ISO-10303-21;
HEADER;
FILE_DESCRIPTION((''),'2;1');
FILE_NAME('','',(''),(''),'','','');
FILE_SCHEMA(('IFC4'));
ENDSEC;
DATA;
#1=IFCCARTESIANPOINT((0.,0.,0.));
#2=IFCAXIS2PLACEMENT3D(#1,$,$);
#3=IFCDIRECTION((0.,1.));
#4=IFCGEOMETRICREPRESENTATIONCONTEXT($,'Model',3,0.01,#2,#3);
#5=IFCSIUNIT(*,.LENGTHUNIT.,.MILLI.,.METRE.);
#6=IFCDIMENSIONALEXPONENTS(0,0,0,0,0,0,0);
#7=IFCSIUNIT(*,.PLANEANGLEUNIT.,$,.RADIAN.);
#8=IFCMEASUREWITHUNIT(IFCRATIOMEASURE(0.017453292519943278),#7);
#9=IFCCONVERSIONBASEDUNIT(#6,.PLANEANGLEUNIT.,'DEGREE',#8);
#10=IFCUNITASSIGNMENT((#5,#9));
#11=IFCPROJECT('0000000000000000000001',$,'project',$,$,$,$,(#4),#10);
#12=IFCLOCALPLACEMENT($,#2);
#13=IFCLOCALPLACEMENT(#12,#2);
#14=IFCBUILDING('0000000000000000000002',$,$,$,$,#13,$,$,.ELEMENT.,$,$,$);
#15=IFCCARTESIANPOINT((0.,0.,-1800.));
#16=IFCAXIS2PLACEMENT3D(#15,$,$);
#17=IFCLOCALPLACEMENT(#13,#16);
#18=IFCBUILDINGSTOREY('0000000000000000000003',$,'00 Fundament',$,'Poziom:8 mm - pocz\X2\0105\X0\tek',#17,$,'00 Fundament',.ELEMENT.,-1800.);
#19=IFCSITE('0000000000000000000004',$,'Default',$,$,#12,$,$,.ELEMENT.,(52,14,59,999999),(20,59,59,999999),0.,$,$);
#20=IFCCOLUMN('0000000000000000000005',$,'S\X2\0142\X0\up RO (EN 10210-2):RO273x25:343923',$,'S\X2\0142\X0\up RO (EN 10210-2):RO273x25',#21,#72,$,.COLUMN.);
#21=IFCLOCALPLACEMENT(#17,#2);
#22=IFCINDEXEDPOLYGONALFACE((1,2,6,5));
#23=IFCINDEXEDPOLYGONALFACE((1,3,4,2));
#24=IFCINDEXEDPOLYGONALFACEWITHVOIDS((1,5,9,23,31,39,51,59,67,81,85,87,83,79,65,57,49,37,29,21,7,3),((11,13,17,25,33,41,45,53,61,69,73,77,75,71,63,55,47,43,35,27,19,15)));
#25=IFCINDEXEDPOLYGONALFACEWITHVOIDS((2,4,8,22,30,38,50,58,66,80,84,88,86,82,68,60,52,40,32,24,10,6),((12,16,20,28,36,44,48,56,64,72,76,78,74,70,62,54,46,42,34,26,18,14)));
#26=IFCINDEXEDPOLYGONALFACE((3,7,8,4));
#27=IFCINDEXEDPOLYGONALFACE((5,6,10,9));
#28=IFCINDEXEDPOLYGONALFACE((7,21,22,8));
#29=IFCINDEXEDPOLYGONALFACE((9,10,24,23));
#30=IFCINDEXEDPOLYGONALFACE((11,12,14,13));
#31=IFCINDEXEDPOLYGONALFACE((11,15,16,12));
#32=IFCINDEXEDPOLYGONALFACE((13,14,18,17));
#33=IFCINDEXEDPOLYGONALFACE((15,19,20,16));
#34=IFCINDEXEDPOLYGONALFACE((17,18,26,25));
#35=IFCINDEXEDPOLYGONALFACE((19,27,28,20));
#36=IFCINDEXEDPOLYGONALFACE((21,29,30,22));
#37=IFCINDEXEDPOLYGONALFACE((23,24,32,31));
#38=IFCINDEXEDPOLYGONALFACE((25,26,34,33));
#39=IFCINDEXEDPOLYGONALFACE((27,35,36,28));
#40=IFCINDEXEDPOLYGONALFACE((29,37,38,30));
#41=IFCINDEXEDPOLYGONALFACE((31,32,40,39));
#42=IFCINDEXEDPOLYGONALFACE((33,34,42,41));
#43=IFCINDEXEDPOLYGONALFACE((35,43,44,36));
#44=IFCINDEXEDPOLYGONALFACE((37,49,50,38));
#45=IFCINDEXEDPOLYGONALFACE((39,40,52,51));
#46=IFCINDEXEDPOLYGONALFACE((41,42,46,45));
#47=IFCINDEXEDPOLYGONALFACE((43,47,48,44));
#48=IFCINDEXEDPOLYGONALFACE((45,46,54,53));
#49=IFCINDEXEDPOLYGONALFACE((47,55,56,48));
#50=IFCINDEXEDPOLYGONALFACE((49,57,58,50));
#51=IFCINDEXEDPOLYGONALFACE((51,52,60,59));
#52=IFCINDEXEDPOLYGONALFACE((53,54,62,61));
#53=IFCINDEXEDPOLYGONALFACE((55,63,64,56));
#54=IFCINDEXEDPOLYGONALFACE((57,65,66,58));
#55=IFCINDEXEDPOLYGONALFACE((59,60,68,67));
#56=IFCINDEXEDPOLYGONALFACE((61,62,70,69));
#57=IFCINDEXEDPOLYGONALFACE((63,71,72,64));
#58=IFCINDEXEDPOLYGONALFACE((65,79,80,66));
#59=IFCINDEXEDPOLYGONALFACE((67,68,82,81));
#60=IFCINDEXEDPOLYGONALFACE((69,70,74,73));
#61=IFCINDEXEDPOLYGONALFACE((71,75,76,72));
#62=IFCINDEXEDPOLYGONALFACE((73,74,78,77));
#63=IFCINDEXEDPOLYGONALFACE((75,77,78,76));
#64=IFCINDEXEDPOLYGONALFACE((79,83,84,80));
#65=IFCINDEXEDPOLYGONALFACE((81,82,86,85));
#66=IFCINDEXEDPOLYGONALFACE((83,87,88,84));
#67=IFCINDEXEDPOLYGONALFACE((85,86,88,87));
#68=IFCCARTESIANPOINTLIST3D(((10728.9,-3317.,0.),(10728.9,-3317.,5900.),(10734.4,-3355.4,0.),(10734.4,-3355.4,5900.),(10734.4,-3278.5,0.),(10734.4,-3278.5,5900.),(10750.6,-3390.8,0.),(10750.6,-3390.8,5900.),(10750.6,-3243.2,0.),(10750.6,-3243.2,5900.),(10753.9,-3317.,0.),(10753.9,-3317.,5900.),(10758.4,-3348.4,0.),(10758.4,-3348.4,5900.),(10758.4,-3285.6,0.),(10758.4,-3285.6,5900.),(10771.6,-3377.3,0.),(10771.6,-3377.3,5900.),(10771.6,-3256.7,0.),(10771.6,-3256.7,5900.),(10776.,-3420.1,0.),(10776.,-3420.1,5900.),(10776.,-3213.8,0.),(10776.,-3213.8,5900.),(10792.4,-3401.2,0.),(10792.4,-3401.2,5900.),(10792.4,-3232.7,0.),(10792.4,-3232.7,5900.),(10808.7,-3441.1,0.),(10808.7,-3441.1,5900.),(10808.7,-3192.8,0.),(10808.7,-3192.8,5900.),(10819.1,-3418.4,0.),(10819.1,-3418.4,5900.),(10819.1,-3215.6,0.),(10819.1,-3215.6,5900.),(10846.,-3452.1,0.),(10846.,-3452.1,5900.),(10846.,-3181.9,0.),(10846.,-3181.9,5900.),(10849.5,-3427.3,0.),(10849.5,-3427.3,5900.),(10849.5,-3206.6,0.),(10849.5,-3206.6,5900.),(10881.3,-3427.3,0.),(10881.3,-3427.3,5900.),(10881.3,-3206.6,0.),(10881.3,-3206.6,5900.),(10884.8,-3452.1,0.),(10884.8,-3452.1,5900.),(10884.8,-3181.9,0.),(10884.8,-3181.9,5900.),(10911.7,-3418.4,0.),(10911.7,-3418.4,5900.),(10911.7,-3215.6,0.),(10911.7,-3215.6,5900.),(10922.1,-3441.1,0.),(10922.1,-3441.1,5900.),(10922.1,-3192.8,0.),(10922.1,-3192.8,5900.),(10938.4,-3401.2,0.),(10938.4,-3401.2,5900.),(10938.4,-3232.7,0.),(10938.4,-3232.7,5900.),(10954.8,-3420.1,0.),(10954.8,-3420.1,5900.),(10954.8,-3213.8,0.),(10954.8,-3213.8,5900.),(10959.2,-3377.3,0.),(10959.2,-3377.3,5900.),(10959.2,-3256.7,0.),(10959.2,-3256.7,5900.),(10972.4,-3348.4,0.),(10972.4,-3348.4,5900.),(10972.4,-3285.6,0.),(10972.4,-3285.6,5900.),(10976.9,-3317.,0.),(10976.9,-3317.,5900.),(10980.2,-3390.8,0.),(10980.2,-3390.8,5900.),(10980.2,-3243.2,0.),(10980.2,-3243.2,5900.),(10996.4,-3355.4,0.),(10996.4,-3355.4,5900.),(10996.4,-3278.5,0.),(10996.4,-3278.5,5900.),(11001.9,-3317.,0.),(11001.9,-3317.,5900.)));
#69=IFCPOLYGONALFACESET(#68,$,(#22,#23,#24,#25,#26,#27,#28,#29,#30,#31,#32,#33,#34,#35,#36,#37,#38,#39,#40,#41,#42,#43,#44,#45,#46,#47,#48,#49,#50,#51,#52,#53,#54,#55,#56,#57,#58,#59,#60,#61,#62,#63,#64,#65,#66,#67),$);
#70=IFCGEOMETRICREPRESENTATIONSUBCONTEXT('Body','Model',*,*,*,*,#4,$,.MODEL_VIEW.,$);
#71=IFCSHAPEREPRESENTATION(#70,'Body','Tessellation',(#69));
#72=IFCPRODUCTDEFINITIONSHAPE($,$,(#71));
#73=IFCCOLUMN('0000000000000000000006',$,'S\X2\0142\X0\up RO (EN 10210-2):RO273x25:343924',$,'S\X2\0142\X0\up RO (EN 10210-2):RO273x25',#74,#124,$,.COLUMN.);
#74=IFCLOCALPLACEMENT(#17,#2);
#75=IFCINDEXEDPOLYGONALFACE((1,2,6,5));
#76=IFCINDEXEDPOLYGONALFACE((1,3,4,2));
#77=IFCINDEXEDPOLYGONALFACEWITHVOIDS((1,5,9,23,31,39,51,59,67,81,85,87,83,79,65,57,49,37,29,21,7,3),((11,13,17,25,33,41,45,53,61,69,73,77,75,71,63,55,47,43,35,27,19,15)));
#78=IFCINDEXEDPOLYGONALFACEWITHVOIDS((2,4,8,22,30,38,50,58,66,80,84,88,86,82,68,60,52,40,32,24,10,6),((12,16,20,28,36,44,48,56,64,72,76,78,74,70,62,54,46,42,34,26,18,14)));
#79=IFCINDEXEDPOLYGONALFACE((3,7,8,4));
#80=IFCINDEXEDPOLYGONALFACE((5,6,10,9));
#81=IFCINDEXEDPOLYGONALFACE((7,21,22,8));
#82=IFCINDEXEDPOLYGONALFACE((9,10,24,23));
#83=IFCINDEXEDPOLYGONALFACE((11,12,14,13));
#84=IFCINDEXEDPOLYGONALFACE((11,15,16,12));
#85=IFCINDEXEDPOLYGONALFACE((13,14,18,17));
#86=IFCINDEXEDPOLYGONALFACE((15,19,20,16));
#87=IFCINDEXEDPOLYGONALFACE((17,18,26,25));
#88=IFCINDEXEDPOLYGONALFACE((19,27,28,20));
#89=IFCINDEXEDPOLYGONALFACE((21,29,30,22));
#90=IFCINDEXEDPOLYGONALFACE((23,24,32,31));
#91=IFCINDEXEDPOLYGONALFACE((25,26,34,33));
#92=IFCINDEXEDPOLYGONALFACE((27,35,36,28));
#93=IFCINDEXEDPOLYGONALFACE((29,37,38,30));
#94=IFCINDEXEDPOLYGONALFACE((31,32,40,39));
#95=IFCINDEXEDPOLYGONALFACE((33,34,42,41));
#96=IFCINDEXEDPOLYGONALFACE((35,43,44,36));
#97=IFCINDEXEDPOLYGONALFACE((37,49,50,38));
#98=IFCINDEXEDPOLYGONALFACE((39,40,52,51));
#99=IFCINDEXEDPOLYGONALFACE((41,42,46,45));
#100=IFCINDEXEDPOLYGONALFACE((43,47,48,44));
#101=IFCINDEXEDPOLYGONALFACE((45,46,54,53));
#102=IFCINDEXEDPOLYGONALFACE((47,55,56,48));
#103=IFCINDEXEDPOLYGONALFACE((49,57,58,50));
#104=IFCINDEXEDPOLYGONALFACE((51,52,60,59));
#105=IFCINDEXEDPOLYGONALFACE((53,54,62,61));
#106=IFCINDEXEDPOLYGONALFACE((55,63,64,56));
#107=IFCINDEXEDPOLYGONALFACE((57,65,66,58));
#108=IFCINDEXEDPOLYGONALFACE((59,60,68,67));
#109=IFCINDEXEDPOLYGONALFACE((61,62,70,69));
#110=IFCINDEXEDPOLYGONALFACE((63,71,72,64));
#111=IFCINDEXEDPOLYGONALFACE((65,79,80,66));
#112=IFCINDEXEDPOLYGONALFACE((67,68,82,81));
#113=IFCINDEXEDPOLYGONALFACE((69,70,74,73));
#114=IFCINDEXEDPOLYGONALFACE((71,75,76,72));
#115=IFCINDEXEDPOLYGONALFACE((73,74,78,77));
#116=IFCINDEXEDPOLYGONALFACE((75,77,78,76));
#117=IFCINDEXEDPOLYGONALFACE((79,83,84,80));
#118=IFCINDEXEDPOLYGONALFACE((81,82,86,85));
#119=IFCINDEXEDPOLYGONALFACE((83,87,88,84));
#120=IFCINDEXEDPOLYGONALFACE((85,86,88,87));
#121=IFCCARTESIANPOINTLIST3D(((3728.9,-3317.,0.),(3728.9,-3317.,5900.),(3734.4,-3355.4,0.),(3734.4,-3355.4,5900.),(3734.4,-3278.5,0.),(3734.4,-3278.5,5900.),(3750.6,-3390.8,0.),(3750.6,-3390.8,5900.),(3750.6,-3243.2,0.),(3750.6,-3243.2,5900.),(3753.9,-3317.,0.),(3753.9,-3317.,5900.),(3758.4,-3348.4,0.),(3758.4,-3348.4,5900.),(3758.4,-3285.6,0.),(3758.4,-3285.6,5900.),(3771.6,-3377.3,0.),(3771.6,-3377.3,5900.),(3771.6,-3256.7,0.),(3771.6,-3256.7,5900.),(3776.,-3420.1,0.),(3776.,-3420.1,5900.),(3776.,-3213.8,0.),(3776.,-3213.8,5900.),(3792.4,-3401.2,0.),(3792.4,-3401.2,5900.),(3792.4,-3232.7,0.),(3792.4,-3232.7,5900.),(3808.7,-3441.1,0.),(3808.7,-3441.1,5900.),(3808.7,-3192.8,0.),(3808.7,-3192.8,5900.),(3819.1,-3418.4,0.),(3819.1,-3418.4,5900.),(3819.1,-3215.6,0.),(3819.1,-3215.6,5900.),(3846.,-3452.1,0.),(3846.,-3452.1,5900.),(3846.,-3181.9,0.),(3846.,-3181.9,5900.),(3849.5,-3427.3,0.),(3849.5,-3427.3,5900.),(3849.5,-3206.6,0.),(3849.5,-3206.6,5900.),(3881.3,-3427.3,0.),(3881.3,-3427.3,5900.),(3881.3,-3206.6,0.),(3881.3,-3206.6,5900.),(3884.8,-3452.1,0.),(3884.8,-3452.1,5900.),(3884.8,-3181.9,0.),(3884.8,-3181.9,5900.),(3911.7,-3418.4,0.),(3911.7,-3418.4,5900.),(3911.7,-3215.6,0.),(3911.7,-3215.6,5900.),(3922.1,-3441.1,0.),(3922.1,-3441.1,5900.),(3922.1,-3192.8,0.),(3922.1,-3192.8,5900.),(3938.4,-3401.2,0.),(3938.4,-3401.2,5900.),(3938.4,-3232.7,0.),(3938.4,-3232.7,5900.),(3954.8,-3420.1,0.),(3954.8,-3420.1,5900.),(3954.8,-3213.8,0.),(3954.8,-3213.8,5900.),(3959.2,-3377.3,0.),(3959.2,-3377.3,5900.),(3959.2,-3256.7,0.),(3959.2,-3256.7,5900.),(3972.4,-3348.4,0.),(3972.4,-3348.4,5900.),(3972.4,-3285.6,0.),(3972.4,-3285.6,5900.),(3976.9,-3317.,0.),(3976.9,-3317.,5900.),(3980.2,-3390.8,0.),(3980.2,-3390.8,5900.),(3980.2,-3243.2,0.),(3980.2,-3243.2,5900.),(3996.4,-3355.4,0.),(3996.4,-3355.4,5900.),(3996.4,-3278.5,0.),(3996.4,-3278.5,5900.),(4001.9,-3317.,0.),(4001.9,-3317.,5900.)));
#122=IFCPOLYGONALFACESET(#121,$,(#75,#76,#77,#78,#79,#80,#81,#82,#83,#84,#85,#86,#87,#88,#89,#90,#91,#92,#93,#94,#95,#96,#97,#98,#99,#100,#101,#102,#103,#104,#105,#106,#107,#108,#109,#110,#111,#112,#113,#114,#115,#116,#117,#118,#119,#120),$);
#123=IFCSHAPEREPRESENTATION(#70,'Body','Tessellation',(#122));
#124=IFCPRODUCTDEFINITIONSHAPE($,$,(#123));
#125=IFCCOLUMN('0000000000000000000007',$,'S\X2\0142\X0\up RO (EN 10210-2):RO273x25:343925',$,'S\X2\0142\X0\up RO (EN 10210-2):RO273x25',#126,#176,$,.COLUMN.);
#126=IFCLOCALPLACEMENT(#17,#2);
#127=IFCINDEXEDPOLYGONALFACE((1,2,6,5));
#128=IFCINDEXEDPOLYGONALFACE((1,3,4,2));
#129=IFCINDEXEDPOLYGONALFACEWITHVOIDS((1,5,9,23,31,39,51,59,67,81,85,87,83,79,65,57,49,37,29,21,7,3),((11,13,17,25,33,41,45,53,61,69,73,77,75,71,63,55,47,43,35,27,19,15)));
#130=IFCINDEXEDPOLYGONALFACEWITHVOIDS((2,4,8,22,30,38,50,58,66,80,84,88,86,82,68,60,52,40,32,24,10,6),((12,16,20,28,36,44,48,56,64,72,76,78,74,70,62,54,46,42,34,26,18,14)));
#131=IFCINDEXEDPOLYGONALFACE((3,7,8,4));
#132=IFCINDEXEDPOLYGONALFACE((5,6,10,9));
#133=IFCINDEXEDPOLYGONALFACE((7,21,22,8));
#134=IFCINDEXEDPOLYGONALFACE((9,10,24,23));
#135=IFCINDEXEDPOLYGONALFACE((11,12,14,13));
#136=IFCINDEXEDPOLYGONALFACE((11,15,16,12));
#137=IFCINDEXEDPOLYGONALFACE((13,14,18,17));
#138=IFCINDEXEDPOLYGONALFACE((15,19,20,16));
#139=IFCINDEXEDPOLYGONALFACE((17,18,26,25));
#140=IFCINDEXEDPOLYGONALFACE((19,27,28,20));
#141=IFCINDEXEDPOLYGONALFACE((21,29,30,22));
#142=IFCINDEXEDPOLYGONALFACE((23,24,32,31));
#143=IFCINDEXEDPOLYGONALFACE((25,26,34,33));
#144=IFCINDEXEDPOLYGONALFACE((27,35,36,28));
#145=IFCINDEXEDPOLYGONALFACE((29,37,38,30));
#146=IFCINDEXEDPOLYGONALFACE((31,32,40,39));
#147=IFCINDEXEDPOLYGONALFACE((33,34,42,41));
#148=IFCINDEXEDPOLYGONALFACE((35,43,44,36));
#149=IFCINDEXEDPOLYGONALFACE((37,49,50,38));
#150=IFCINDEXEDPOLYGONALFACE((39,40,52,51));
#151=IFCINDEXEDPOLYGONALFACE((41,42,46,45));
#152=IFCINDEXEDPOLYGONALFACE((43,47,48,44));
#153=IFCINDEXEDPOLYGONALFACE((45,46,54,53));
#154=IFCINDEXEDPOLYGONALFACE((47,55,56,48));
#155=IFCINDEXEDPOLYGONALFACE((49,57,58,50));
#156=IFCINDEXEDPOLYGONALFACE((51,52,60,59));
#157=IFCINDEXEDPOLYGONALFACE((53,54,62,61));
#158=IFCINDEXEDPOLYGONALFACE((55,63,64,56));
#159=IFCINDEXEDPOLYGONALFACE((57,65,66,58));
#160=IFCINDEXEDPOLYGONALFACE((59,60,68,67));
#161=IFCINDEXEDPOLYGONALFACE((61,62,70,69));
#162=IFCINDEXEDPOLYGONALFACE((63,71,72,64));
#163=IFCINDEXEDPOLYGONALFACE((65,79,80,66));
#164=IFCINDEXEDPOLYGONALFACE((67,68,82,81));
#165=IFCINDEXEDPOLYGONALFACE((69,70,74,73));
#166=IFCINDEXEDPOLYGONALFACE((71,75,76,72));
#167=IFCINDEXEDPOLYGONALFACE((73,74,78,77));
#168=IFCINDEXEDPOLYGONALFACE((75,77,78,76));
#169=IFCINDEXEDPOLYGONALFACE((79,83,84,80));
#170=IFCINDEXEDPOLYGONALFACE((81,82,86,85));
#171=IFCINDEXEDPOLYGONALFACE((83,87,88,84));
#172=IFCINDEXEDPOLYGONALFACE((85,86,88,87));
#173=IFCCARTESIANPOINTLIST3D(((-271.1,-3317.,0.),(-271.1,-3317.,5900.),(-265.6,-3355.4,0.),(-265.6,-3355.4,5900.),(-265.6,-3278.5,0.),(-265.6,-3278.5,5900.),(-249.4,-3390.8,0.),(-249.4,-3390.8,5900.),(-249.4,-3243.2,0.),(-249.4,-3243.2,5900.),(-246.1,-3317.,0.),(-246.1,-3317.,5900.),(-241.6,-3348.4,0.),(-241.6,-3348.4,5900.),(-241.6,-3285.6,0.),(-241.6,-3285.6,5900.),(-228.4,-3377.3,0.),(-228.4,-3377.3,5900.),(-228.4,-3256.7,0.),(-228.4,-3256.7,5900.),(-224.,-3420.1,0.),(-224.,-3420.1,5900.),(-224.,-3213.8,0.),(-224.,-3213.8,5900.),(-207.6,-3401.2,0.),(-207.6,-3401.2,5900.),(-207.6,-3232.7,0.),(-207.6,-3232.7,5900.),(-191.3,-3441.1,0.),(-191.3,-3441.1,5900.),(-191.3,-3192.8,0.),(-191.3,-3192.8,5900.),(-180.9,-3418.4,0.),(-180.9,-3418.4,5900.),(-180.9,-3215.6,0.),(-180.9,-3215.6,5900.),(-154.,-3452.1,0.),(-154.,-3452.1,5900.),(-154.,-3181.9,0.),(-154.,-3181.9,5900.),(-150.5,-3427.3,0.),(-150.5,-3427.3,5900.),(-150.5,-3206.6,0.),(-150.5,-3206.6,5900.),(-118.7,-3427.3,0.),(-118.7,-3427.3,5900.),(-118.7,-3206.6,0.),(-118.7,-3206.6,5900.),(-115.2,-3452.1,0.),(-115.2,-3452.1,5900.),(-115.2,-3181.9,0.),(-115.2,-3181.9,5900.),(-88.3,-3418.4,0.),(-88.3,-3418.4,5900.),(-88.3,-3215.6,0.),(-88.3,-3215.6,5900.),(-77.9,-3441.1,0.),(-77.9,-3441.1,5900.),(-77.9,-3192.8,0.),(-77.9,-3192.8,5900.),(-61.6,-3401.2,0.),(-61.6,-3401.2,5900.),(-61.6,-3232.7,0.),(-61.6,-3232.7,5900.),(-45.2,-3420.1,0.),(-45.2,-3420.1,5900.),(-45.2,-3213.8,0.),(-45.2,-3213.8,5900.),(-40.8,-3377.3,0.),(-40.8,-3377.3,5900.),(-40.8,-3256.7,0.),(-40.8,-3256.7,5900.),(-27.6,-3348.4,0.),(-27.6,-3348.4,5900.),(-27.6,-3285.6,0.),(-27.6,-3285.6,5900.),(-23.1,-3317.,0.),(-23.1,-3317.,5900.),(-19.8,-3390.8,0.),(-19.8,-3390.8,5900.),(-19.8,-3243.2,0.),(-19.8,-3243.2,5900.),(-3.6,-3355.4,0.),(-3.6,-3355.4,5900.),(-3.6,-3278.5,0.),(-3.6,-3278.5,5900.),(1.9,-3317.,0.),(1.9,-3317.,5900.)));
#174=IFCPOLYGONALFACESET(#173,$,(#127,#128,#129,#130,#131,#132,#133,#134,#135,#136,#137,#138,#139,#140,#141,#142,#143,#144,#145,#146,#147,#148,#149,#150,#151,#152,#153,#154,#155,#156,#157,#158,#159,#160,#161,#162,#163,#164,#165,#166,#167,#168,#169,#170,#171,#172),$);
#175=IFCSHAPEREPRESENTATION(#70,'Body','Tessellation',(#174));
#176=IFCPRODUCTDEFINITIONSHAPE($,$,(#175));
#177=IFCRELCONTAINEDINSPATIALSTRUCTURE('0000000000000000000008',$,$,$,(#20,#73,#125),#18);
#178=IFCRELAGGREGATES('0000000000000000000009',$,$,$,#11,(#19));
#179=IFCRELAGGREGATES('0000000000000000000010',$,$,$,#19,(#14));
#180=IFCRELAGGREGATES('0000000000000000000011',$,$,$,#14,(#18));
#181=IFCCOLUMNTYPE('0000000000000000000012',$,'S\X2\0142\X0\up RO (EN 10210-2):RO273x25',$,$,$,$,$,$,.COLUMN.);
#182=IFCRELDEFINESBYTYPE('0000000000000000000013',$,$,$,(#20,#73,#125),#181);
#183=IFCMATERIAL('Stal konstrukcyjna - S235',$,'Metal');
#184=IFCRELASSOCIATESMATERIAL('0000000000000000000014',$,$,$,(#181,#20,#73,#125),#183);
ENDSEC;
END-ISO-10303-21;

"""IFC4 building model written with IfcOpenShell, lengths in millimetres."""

from ifc_helpers import new_model, entity, si_unit, converted_unit, direction, frame, origin, place, context, subcontext, project, spatial, arc, indexed_curve, outline, extrude, source, transform, mapped, material, type_object, type_shapes, element, save


model = new_model("IFC4")

# Units and contexts
model_context = context("Model", 3, precision=0.01, world=origin(), true_north=direction((0.0, 1.0)))
body_context = subcontext(model_context, "Body", "Model", "MODEL_VIEW")
ifc_project = project(units=[si_unit("LENGTHUNIT", "METRE", prefix="MILLI"), converted_unit("PLANEANGLEUNIT", "DEGREE", entity("IfcRatioMeasure", 0.017453292519943278), si_unit("PLANEANGLEUNIT", "RADIAN"), dimensions=[0, 0, 0, 0, 0, 0, 0])], contexts=[model_context])

# Site, building, storey
site_placement = place(None, origin())
site = spatial("IfcSite", under=ifc_project, at=site_placement, Name="Default", CompositionType="ELEMENT", RefLatitude=(52, 14, 59, 999999), RefLongitude=(20, 59, 59, 999999), RefElevation=0.0)
building_placement = place(site_placement, origin())
building = spatial("IfcBuilding", under=site, at=building_placement, CompositionType="ELEMENT")
storey_placement = place(building_placement, frame((0.0, 0.0, -1800.0)))
storey = spatial("IfcBuildingStorey", under=building, at=storey_placement, Name="00 Fundament", ObjectType="Poziom:8 mm - początek", LongName="00 Fundament", CompositionType="ELEMENT", Elevation=-1800.0)

# Columns
ifc_material_1 = material(Name="Stal konstrukcyjna - S235", Category="Metal")
column_type = type_object("IfcColumnType", Name="Słup RO (EN 10210-2):RO273x25", PredefinedType="COLUMN", material=ifc_material_1)
shared_shape = source(origin(), body_context, "Body", "SweptSolid", [
    extrude(outline(indexed_curve([(-136.5, 0.0), (0.0, -136.5), (136.5, 0.0), (0.0, 136.5)], segments=[arc(1, 2, 3), arc(3, 4, 1)], self_intersect=False), holes=[indexed_curve([(-111.5, 0.0), (0.0, 111.5), (111.5, 0.0), (0.0, -111.5)], segments=[arc(1, 2, 3), arc(3, 4, 1)], self_intersect=False)]), frame((0.0, 0.0, -1800.0)), (0.0, 0.0, 1.0), 5900.0),
])
type_shapes(column_type, [shared_shape])
for number, where, name in (
    (1, (10865.4, -3317.0, 1800.0), "Słup RO (EN 10210-2):RO273x25:343923"),
    (2, (3865.4, -3317.0, 1800.0), "Słup RO (EN 10210-2):RO273x25:343924"),
    (3, (-134.6, -3317.0, 1800.0), "Słup RO (EN 10210-2):RO273x25:343925"),
):
    element("IfcColumn", number, at=place(storey_placement, frame(where)), inside=storey, type_object=column_type, material=ifc_material_1, Name=name, ObjectType="Słup RO (EN 10210-2):RO273x25", PredefinedType="COLUMN", context=body_context, shape_type="MappedRepresentation", body=[
        mapped(shared_shape, transform((0.0, 0.0, 0.0), scale=1.0)),
    ])

save(model, "model.ifc")
